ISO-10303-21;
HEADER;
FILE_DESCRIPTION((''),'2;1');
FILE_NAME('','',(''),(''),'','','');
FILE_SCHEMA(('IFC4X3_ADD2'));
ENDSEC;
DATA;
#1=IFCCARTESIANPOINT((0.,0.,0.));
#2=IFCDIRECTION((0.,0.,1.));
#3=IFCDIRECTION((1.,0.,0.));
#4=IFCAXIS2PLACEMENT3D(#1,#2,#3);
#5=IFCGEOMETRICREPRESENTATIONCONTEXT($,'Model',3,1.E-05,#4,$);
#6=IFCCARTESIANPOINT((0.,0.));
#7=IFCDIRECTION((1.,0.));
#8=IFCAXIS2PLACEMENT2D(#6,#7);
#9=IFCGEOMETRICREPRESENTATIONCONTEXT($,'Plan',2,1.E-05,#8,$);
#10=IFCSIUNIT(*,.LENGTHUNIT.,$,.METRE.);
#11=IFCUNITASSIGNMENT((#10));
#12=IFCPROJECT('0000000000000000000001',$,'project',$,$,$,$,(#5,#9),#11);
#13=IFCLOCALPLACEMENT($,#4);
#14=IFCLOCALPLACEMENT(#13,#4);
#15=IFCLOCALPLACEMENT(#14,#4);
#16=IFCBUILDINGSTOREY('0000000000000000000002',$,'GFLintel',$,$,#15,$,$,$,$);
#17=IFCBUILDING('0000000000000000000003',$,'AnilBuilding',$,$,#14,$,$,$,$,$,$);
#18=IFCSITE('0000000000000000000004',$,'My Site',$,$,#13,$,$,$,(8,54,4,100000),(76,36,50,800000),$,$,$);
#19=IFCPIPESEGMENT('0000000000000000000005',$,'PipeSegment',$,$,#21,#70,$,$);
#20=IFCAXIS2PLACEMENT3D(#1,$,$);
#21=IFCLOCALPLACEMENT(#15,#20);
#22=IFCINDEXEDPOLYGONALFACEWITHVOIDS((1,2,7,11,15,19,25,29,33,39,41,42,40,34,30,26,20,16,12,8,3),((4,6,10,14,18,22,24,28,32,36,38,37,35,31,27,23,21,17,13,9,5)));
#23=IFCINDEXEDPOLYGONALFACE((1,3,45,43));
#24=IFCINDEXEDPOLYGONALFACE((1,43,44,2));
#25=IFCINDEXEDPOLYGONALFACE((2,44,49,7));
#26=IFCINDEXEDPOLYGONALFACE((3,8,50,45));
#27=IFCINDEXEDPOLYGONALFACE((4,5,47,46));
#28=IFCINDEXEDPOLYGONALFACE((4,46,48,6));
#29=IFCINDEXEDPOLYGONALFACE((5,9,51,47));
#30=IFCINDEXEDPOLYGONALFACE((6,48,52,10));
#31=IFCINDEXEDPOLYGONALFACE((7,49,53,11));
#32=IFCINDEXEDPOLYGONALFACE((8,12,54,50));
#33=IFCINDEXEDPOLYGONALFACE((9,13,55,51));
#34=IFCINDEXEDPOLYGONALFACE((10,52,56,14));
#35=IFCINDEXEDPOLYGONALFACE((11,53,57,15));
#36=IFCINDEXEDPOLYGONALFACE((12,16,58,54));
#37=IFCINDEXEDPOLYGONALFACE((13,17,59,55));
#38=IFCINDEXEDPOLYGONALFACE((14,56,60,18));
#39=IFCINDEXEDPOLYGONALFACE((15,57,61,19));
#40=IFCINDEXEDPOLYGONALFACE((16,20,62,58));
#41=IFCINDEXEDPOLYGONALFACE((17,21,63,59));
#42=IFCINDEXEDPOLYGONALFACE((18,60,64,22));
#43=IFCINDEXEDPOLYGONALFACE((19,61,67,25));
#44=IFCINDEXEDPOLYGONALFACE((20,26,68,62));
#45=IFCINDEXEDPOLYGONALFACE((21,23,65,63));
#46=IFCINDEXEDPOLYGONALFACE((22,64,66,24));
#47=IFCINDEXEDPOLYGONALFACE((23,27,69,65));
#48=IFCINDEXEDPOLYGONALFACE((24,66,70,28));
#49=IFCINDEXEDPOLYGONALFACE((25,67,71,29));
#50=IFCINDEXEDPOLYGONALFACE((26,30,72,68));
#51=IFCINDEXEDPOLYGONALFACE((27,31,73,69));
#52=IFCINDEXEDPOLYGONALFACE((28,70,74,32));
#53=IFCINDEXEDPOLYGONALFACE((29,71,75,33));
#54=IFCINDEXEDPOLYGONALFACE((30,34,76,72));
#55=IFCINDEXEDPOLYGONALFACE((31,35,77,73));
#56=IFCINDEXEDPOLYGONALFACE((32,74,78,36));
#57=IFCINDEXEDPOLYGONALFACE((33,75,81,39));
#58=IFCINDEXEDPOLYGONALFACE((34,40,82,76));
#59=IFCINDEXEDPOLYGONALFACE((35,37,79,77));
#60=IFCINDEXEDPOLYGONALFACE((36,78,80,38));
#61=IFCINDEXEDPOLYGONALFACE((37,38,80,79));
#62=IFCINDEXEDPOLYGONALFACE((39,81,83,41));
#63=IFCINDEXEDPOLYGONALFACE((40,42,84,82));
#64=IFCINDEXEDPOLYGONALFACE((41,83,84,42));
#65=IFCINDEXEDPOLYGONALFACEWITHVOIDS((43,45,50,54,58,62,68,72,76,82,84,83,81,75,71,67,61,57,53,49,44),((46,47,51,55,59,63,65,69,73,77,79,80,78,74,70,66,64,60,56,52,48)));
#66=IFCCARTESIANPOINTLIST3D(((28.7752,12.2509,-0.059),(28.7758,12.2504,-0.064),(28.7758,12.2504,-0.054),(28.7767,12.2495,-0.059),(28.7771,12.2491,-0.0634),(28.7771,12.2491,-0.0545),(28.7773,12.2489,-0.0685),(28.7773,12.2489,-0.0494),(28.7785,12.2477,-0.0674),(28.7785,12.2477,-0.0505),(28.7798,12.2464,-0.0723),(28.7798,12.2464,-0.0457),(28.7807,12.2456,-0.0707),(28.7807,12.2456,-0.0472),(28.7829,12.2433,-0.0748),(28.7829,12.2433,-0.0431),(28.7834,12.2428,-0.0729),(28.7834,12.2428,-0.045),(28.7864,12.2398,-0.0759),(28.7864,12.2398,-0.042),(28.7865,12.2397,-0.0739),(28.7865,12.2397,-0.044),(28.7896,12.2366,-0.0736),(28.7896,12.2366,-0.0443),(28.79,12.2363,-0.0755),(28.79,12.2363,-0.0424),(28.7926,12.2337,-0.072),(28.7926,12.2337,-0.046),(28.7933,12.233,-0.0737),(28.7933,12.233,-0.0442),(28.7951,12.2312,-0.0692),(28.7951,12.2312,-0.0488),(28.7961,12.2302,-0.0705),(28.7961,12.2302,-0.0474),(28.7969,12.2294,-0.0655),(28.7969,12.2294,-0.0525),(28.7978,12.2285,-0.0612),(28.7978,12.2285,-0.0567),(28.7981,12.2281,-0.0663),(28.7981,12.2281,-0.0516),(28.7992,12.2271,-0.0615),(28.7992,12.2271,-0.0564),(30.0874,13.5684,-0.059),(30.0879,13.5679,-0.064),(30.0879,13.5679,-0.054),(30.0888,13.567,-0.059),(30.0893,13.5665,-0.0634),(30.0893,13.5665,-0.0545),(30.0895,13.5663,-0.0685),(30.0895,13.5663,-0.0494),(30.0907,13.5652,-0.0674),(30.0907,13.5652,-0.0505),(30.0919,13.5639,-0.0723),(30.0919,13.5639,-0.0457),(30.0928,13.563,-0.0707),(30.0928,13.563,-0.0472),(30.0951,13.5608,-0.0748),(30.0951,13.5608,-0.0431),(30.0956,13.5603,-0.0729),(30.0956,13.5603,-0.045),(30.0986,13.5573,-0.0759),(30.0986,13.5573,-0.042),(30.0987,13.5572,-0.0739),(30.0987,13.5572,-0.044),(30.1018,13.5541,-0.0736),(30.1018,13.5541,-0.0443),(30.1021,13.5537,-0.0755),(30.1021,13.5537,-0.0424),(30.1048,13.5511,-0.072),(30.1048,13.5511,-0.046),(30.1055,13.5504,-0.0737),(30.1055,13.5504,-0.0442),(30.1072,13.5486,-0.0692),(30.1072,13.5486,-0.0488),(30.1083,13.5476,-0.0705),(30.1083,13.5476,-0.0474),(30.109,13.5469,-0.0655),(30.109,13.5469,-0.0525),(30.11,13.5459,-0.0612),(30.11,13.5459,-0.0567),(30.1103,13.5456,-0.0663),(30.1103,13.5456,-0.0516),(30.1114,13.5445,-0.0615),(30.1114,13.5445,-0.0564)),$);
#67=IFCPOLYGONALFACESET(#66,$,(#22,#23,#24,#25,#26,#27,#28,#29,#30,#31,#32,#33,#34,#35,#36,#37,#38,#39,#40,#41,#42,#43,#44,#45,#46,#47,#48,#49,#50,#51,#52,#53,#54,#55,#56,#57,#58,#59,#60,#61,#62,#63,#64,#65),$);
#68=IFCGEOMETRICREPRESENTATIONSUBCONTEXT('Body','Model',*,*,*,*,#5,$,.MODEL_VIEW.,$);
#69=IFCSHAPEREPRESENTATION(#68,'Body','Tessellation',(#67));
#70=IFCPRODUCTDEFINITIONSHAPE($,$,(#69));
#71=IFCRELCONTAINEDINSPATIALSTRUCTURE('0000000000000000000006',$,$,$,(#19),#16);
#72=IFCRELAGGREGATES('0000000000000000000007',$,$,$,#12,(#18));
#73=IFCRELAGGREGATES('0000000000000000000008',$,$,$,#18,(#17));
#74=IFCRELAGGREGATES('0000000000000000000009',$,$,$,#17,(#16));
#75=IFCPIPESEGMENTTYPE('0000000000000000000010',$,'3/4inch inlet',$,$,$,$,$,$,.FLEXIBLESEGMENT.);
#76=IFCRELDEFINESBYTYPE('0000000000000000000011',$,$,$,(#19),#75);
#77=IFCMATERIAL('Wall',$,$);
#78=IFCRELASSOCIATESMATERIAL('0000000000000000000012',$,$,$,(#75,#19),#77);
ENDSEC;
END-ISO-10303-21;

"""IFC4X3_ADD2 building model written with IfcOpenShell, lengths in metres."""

from ifc_helpers import new_model, si_unit, frame, origin_with_axes, origin_2d_with_axis, place, context, subcontext, project, spatial, hollow_circle, extrude, material, material_profile, profile_set, profile_usage, type_object, element, save


model = new_model("IFC4X3_ADD2")

# Units and contexts
model_context = context("Model", 3, precision=1e-05, world=origin_with_axes())
plan_context = context("Plan", 2, precision=1e-05, world=origin_2d_with_axis())
body_context = subcontext(model_context, "Body", "Model", "MODEL_VIEW")
ifc_project = project(units=[si_unit("LENGTHUNIT", "METRE")], contexts=[model_context, plan_context])

# Site, building, storey
site_placement = place(None, origin_with_axes())
site = spatial("IfcSite", under=ifc_project, at=site_placement, Name="My Site", RefLatitude=(8, 54, 4, 100000), RefLongitude=(76, 36, 50, 800000))
building_placement = place(site_placement, origin_with_axes())
building = spatial("IfcBuilding", under=site, at=building_placement, Name="AnilBuilding")
storey_placement = place(building_placement, origin_with_axes())
storey = spatial("IfcBuildingStorey", under=building, at=storey_placement, Name="GFLintel")

# Shared definitions
ifc_material_1 = material(Name="Wall")

# Pipe segment
ifc_material_profile_1 = material_profile(ifc_material_1, hollow_circle(Radius=0.017, WallThickness=0.002))
ifc_profile_set_1 = profile_set([ifc_material_profile_1], Name="coldwater")
ifc_profile_usage_1 = profile_usage(ifc_profile_set_1)
pipe_segment_type = type_object("IfcPipeSegmentType", Name="3/4inch inlet", PredefinedType="FLEXIBLESEGMENT", material=ifc_profile_set_1)
pipe_segment_placement = place(storey_placement, frame((28.7873, 12.239, -0.059), z_axis=(0.705686, 0.708524, 0.0), x_axis=(-0.708524, 0.705686, 0.0)))
element("IfcPipeSegment", 1, at=pipe_segment_placement, inside=storey, type_object=pipe_segment_type, material=ifc_profile_usage_1, Name="PipeSegment", context=body_context, shape_type="SweptSolid", body=[
    extrude(hollow_circle(Radius=0.017, WallThickness=0.002), origin_with_axes(), (0.0, 0.0, 1.0), 1.8594),
])

save(model, "model.ifc")
